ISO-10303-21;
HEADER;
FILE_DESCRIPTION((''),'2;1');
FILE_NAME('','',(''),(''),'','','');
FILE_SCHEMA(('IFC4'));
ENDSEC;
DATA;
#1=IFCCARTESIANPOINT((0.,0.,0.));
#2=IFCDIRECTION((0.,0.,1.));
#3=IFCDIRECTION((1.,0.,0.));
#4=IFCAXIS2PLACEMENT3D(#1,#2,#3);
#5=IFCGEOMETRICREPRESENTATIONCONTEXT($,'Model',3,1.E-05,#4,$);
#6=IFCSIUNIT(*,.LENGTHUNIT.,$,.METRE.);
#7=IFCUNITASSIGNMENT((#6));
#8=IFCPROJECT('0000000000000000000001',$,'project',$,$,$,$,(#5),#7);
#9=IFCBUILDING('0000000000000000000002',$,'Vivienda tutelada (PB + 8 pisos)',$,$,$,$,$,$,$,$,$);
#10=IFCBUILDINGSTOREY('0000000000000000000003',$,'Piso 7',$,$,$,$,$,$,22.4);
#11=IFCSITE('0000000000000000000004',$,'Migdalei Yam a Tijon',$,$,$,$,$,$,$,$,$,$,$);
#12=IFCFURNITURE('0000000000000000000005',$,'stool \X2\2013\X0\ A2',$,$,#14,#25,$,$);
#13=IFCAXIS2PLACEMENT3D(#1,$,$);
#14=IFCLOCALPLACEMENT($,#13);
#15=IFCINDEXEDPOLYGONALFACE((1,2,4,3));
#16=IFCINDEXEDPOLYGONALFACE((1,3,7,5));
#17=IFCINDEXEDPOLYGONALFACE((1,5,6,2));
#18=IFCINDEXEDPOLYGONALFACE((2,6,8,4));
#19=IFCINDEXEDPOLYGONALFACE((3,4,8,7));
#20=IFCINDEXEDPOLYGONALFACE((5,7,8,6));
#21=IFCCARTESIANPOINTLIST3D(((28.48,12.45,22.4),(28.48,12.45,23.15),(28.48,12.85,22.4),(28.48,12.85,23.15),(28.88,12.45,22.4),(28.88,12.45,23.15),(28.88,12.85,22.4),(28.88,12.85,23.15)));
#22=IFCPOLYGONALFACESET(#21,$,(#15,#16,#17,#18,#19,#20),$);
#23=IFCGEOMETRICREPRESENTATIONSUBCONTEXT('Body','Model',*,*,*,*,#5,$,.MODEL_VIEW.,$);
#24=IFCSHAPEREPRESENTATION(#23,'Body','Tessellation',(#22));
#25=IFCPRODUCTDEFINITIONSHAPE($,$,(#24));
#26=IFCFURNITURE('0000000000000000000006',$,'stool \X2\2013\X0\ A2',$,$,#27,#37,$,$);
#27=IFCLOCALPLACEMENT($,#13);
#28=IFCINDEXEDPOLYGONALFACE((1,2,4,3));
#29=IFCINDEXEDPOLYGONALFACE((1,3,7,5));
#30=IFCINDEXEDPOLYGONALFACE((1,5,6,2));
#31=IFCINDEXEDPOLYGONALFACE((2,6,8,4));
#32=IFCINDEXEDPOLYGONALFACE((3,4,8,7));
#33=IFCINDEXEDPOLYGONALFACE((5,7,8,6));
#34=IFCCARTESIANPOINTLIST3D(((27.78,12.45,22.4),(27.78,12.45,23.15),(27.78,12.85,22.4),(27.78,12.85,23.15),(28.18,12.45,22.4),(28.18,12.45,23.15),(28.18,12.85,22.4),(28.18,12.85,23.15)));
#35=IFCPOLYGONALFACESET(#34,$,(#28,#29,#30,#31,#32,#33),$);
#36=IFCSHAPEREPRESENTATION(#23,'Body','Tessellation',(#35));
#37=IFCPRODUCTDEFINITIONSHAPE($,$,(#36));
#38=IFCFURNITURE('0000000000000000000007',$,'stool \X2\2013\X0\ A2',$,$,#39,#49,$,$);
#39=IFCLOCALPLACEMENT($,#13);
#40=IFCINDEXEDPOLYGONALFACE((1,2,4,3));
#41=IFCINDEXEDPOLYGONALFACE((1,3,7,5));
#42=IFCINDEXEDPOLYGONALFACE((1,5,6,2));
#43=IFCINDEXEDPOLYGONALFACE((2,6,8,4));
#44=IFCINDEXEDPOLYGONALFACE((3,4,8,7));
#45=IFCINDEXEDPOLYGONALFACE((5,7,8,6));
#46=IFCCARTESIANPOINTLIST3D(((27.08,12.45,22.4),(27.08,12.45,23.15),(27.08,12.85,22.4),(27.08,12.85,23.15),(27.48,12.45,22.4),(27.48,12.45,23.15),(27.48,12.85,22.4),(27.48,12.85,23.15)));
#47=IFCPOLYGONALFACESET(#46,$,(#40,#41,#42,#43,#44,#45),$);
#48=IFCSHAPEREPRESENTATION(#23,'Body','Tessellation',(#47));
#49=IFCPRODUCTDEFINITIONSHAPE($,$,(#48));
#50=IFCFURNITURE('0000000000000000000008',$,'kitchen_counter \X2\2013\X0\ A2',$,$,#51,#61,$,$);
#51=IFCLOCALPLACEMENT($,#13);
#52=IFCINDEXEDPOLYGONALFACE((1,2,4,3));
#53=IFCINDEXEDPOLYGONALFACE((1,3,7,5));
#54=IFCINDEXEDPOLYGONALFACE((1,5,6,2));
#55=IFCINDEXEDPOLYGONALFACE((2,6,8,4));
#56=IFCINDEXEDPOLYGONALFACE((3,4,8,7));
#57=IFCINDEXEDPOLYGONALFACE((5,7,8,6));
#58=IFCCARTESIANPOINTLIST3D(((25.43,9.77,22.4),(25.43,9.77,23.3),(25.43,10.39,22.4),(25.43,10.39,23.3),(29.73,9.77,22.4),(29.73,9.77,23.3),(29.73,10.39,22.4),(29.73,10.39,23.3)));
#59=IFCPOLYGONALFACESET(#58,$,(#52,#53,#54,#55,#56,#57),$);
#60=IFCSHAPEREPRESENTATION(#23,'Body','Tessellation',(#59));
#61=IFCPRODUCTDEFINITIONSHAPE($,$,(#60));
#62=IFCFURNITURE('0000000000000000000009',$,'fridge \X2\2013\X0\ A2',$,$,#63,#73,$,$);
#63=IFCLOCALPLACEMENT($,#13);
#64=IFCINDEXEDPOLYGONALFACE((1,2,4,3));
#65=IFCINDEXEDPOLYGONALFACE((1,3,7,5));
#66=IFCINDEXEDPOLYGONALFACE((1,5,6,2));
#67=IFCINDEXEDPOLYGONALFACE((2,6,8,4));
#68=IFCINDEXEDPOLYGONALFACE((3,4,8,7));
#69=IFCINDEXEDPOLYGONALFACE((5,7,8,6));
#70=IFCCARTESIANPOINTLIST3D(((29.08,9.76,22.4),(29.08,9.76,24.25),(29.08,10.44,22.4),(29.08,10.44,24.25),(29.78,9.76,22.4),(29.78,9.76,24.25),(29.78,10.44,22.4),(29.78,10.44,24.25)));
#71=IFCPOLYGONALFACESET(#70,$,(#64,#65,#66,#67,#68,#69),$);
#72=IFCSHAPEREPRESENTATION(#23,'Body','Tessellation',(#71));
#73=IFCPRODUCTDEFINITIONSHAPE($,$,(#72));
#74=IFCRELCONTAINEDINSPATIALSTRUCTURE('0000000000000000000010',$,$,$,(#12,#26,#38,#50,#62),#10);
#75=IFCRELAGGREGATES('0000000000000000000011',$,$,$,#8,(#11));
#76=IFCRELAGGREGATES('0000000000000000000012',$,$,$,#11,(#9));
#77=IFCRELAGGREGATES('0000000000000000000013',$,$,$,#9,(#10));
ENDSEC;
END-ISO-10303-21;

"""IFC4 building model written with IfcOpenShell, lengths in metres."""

from ifc_helpers import new_model, si_unit, frame, origin_with_axes, context, subcontext, project, spatial, line, indexed_curve, outline, extrude, element, save


model = new_model("IFC4")

# Units and contexts
model_context = context("Model", 3, precision=1e-05, world=origin_with_axes())
body_context = subcontext(model_context, "Body", "Model", "MODEL_VIEW")
ifc_project = project(units=[si_unit("LENGTHUNIT", "METRE")], contexts=[model_context])

# Site, building, storey
site = spatial("IfcSite", under=ifc_project, Name="Migdalei Yam a Tijon")
building = spatial("IfcBuilding", under=site, Name="Vivienda tutelada (PB + 8 pisos)")
storey = spatial("IfcBuildingStorey", under=building, Name="Piso 7", Elevation=22.4)

# Furniture
element("IfcFurniture", 1, inside=storey, Name="stool – A2", context=body_context, shape_type="SweptSolid", body=[
    extrude(outline(indexed_curve([(0.0, 0.0), (0.4, 0.0), (0.4, 0.4), (0.0, 0.4)], segments=[line(1, 2, 3, 4, 1)])), frame((28.48, 12.45, 22.4), z_axis=(0.0, 0.0, 1.0), x_axis=(1.0, 0.0, 0.0)), (0.0, 0.0, 1.0), 0.75),
])
element("IfcFurniture", 2, inside=storey, Name="stool – A2", context=body_context, shape_type="SweptSolid", body=[
    extrude(outline(indexed_curve([(0.0, 0.0), (0.4, 0.0), (0.4, 0.4), (0.0, 0.4)], segments=[line(1, 2, 3, 4, 1)])), frame((27.78, 12.45, 22.4), z_axis=(0.0, 0.0, 1.0), x_axis=(1.0, 0.0, 0.0)), (0.0, 0.0, 1.0), 0.75),
])
element("IfcFurniture", 3, inside=storey, Name="stool – A2", context=body_context, shape_type="SweptSolid", body=[
    extrude(outline(indexed_curve([(0.0, 0.0), (0.4, 0.0), (0.4, 0.4), (0.0, 0.4)], segments=[line(1, 2, 3, 4, 1)])), frame((27.08, 12.45, 22.4), z_axis=(0.0, 0.0, 1.0), x_axis=(1.0, 0.0, 0.0)), (0.0, 0.0, 1.0), 0.75),
])
element("IfcFurniture", 4, inside=storey, Name="kitchen_counter – A2", context=body_context, shape_type="SweptSolid", body=[
    extrude(outline(indexed_curve([(0.0, 0.0), (4.3, 0.0), (4.3, 0.62), (0.0, 0.62)], segments=[line(1, 2, 3, 4, 1)])), frame((25.43, 9.77, 22.4), z_axis=(0.0, 0.0, 1.0), x_axis=(1.0, 0.0, 0.0)), (0.0, 0.0, 1.0), 0.9),
])
element("IfcFurniture", 5, inside=storey, Name="fridge – A2", context=body_context, shape_type="SweptSolid", body=[
    extrude(outline(indexed_curve([(0.0, 0.0), (0.7, 0.0), (0.7, 0.68), (0.0, 0.68)], segments=[line(1, 2, 3, 4, 1)])), frame((29.08, 9.76, 22.4), z_axis=(0.0, 0.0, 1.0), x_axis=(1.0, 0.0, 0.0)), (0.0, 0.0, 1.0), 1.85),
])

save(model, "model.ifc")
